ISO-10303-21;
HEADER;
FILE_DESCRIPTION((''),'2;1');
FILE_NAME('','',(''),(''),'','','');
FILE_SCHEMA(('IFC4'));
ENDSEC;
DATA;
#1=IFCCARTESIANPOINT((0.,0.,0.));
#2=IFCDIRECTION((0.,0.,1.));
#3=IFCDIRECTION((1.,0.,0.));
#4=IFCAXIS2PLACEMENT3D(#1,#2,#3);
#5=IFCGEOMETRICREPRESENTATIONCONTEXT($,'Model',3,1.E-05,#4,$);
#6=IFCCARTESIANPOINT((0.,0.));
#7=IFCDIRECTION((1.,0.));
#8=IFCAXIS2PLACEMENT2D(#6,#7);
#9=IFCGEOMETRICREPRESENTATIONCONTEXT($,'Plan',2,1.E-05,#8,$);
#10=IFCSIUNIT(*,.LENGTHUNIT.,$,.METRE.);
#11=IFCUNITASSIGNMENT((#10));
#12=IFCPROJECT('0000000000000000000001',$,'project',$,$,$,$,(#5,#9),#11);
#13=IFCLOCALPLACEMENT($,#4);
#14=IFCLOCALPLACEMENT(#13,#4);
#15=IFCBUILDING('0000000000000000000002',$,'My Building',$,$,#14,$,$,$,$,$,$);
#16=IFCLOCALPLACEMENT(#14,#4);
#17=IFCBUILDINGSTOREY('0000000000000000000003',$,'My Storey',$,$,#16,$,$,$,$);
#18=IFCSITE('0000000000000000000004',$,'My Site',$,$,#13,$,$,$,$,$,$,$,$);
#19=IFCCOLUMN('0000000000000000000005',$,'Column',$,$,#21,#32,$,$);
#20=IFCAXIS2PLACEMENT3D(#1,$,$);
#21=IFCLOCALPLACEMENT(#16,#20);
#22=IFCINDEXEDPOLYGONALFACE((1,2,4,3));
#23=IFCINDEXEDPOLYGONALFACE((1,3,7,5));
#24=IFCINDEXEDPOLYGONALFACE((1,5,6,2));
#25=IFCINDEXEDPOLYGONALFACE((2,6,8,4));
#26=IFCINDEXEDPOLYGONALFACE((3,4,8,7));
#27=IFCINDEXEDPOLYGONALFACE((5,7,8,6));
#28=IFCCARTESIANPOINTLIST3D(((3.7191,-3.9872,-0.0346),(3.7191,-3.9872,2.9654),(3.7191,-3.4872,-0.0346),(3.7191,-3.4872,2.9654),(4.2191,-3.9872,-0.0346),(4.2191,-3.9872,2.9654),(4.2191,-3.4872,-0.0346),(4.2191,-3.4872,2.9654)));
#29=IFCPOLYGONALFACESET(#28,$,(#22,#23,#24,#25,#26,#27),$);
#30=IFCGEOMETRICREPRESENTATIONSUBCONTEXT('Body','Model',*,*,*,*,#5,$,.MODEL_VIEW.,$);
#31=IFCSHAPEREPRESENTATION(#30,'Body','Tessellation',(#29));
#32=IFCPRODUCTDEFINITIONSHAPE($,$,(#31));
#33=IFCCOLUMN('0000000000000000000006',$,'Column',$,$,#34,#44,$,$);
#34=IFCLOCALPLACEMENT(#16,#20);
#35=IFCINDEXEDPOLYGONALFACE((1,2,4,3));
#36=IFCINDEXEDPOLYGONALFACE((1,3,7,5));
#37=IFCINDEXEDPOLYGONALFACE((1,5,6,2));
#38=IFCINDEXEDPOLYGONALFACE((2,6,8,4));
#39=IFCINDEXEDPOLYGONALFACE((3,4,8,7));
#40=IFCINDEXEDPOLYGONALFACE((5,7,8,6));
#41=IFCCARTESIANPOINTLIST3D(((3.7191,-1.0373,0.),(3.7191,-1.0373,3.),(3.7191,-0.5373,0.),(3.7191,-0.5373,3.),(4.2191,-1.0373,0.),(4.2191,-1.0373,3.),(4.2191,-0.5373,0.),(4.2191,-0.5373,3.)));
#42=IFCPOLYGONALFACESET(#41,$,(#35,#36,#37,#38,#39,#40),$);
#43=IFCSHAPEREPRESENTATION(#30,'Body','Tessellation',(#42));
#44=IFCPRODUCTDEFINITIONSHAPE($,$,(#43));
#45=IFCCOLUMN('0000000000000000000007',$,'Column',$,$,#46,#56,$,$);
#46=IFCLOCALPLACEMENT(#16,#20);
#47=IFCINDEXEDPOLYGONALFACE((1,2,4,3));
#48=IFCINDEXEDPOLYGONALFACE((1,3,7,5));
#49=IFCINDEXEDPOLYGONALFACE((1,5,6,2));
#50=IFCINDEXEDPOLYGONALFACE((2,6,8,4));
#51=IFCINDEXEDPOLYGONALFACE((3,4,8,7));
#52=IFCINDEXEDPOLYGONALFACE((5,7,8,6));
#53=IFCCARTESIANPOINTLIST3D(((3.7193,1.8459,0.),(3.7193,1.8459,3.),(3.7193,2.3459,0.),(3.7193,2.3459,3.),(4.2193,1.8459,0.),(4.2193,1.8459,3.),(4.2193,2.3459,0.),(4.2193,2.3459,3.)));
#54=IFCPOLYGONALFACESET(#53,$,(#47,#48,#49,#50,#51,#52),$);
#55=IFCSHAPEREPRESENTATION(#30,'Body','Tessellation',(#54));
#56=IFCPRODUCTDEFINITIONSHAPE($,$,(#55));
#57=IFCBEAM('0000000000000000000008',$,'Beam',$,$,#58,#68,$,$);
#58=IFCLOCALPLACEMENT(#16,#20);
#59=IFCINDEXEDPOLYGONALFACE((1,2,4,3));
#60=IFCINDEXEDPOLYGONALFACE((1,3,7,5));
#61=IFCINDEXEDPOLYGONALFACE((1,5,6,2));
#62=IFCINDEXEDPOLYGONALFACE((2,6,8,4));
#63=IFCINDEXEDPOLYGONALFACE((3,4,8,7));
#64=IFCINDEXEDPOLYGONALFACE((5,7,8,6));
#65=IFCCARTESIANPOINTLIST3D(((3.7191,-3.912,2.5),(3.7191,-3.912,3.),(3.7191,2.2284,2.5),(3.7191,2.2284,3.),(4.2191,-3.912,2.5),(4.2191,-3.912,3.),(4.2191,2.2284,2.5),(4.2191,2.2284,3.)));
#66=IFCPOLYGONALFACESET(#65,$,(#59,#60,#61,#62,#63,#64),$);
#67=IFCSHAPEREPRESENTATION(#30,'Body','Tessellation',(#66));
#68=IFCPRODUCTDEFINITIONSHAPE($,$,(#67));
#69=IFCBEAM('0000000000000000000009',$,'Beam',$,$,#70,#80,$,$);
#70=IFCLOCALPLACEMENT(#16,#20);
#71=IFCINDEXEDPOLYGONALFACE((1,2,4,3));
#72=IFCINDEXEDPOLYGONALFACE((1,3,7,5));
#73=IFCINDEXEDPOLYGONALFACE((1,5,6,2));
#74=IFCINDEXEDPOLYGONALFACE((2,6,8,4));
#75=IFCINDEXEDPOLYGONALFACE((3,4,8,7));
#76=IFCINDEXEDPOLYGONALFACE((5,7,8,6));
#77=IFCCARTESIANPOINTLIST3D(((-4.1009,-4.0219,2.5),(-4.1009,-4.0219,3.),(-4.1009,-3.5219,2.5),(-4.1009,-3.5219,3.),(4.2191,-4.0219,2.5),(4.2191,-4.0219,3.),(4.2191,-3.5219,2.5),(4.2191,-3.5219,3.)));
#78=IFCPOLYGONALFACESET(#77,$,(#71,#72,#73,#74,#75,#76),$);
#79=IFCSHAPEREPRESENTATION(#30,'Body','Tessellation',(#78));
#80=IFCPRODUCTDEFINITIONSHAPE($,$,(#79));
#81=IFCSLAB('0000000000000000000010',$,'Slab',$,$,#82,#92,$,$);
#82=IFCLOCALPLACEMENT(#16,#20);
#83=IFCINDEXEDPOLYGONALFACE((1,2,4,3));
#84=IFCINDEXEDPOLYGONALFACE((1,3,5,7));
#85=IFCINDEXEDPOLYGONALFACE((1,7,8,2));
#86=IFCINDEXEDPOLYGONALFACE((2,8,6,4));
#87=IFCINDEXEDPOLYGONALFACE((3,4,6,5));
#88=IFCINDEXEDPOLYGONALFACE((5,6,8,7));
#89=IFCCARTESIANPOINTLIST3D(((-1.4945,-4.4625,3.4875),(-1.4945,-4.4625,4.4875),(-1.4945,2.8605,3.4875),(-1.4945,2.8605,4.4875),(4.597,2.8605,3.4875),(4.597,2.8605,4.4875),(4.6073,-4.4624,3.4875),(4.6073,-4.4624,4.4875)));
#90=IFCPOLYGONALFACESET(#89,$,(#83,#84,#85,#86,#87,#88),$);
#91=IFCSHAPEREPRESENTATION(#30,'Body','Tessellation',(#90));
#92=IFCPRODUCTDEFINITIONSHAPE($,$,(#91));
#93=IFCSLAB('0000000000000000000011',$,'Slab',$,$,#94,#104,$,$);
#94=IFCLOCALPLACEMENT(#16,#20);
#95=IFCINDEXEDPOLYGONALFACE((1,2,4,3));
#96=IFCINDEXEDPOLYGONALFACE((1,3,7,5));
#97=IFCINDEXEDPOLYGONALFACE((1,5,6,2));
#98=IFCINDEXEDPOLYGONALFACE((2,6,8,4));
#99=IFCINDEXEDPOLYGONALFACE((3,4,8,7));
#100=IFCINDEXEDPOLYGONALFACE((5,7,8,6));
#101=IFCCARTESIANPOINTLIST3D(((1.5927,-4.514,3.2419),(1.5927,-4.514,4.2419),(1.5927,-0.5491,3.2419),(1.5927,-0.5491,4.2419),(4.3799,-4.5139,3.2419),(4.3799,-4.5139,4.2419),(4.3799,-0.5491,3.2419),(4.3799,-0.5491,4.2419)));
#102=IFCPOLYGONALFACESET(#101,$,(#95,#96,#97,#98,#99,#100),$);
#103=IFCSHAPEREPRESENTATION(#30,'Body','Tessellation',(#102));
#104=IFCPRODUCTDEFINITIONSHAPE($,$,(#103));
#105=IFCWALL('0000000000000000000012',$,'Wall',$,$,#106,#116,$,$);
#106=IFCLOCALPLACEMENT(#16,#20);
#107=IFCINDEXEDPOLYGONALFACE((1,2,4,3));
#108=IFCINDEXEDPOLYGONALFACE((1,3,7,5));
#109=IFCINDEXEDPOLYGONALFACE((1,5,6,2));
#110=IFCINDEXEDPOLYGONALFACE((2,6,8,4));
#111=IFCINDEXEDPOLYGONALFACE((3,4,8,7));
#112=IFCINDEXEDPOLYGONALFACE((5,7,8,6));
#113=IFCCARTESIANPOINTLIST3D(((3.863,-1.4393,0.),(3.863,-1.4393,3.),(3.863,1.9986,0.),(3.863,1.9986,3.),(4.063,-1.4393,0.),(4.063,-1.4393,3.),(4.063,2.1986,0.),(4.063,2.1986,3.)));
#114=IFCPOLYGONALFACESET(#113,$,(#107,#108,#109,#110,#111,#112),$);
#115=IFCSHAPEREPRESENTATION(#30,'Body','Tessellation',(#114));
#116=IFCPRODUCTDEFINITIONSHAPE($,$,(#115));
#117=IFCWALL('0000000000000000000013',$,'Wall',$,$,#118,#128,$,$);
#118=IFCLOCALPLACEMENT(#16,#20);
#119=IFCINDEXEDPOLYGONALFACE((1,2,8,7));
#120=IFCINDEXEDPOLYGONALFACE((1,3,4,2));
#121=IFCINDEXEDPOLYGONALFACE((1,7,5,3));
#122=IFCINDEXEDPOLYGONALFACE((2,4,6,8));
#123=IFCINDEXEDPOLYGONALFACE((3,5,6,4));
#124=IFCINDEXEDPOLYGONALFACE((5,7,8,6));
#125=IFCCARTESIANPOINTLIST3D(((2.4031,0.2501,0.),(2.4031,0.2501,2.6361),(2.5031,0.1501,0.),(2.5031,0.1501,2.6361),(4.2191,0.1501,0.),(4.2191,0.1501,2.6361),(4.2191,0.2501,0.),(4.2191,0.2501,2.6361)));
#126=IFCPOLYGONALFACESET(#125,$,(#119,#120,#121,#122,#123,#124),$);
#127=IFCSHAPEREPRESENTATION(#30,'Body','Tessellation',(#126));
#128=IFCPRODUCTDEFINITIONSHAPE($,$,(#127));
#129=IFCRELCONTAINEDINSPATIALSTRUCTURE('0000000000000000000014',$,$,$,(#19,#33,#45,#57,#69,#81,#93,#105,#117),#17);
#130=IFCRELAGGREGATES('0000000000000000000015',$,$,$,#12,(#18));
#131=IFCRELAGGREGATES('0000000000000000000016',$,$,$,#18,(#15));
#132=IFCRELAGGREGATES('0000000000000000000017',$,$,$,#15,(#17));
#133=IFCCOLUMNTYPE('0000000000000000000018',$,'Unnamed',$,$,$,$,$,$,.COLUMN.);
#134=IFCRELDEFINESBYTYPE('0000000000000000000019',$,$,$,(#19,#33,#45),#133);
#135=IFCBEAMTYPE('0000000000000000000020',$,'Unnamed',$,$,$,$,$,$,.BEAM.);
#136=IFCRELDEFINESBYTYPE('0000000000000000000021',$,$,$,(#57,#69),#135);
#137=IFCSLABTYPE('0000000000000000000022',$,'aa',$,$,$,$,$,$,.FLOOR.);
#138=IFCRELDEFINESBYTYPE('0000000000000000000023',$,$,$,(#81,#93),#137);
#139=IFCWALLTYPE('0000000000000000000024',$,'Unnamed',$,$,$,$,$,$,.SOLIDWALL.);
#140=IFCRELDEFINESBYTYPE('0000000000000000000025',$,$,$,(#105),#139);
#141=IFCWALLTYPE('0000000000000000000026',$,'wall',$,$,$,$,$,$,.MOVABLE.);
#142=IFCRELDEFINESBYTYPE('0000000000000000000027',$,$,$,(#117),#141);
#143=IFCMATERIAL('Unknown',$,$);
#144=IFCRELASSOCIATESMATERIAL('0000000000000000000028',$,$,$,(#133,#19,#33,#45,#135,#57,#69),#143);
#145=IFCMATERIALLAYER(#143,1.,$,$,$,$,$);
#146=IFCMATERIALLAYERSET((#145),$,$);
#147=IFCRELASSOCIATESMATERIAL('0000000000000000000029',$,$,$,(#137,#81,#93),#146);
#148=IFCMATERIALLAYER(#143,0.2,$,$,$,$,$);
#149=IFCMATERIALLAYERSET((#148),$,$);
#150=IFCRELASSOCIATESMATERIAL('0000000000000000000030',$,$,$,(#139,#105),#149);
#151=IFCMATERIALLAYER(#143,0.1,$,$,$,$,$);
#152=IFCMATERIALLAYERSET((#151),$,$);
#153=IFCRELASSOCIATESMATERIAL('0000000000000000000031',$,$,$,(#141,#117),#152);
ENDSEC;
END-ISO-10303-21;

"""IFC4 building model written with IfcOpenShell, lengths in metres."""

from ifc_helpers import new_model, si_unit, frame, origin_with_axes, origin_2d_with_axis, place, context, subcontext, project, spatial, line, indexed_curve, rectangle, outline, extrude, material, layer, layer_set, layer_usage, material_profile, profile_set, profile_usage, type_object, element, save


model = new_model("IFC4")

# Units and contexts
model_context = context("Model", 3, precision=1e-05, world=origin_with_axes())
plan_context = context("Plan", 2, precision=1e-05, world=origin_2d_with_axis())
body_context_1 = subcontext(model_context, "Body", "Model", "MODEL_VIEW")
ifc_project = project(units=[si_unit("LENGTHUNIT", "METRE")], contexts=[model_context, plan_context])

# Site, building, storey
site_placement = place(None, origin_with_axes())
site = spatial("IfcSite", under=ifc_project, at=site_placement, Name="My Site")
building_placement = place(site_placement, origin_with_axes())
building = spatial("IfcBuilding", under=site, at=building_placement, Name="My Building")
storey_placement = place(building_placement, origin_with_axes())
storey = spatial("IfcBuildingStorey", under=building, at=storey_placement, Name="My Storey")

# Columns
ifc_material = material(Name="Unknown")
ifc_material_profile_1 = material_profile(ifc_material, rectangle(XDim=0.5, YDim=0.5))
ifc_profile_set_1 = profile_set([ifc_material_profile_1])
ifc_profile_usage_1 = profile_usage(ifc_profile_set_1, cardinal=5)
column_type = type_object("IfcColumnType", Name="Unnamed", PredefinedType="COLUMN", material=ifc_profile_set_1)
column_1_placement = place(storey_placement, frame((3.9691, -3.7372, -0.0346), z_axis=(0.0, 0.0, 1.0), x_axis=(1.0, 0.0, 0.0)))
element("IfcColumn", 1, at=column_1_placement, inside=storey, type_object=column_type, material=ifc_profile_usage_1, Name="Column", context=body_context_1, shape_type="SweptSolid", body=[
    extrude(rectangle(XDim=0.5, YDim=0.5), origin_with_axes(), (0.0, 0.0, 1.0), 3.0),
])
ifc_profile_usage_2 = profile_usage(ifc_profile_set_1, cardinal=5)
column_2_placement = place(storey_placement, frame((3.9691, -0.7873, 0.0), z_axis=(0.0, 0.0, 1.0), x_axis=(1.0, 0.0, 0.0)))
element("IfcColumn", 2, at=column_2_placement, inside=storey, type_object=column_type, material=ifc_profile_usage_2, Name="Column", context=body_context_1, shape_type="SweptSolid", body=[
    extrude(rectangle(XDim=0.5, YDim=0.5), origin_with_axes(), (0.0, 0.0, 1.0), 3.0),
])
ifc_profile_usage_3 = profile_usage(ifc_profile_set_1, cardinal=5)
column_3_placement = place(storey_placement, frame((3.9693, 2.0959, 0.0), z_axis=(0.0, 0.0, 1.0), x_axis=(1.0, 0.0, 0.0)))
element("IfcColumn", 3, at=column_3_placement, inside=storey, type_object=column_type, material=ifc_profile_usage_3, Name="Column", context=body_context_1, shape_type="SweptSolid", body=[
    extrude(rectangle(XDim=0.5, YDim=0.5), origin_with_axes(), (0.0, 0.0, 1.0), 3.0),
])

# Beams
ifc_material_profile_2 = material_profile(ifc_material, rectangle(XDim=0.5, YDim=0.5))
ifc_profile_set_2 = profile_set([ifc_material_profile_2])
ifc_profile_usage_4 = profile_usage(ifc_profile_set_2, cardinal=5)
beam_type = type_object("IfcBeamType", Name="Unnamed", PredefinedType="BEAM", material=ifc_profile_set_2)
beam_1_placement = place(storey_placement, frame((3.9691, 2.2284, 2.75), z_axis=(0.0, -1.0, 0.0), x_axis=(1.0, 0.0, 0.0)))
element("IfcBeam", 4, at=beam_1_placement, inside=storey, type_object=beam_type, material=ifc_profile_usage_4, Name="Beam", context=body_context_1, shape_type="SweptSolid", body=[
    extrude(rectangle(XDim=0.5, YDim=0.5), origin_with_axes(), (0.0, 0.0, 1.0), 6.1404),
])
ifc_profile_usage_5 = profile_usage(ifc_profile_set_2, cardinal=5)
beam_2_placement = place(storey_placement, frame((4.2191, -3.7719, 2.75), z_axis=(-1.0, 0.0, 0.0), x_axis=(0.0, -1.0, 0.0)))
element("IfcBeam", 5, at=beam_2_placement, inside=storey, type_object=beam_type, material=ifc_profile_usage_5, Name="Beam", context=body_context_1, shape_type="SweptSolid", body=[
    extrude(rectangle(XDim=0.5, YDim=0.5), origin_with_axes(), (0.0, 0.0, 1.0), 8.32),
])

# Slabs
ifc_layer_1 = layer(ifc_material, 1.0)
ifc_layer_set_1 = layer_set([ifc_layer_1])
ifc_layer_usage_1 = layer_usage(ifc_layer_set_1, "AXIS3", "POSITIVE", -1.0)
slab_type = type_object("IfcSlabType", Name="aa", PredefinedType="FLOOR", material=ifc_layer_set_1)
slab_1_placement = place(storey_placement, frame((4.6073, -4.4624, 4.4875), z_axis=(0.0, 0.0, 1.0), x_axis=(1.0, 0.0, 0.0)))
element("IfcSlab", 6, at=slab_1_placement, inside=storey, type_object=slab_type, material=ifc_layer_usage_1, Name="Slab", context=body_context_1, shape_type="SweptSolid", body=[
    extrude(outline(indexed_curve([(0.0, 0.0), (-0.0102, 7.3228), (-6.1017, 7.3228), (-6.1017, -0.0001), (0.0, 0.0)])), frame((0.0, 0.0, -1.0), z_axis=(0.0, 0.0, 1.0), x_axis=(1.0, 0.0, 0.0)), (0.0, 0.0, 1.0), 1.0),
])
ifc_layer_usage_2 = layer_usage(ifc_layer_set_1, "AXIS3", "POSITIVE", -1.0)
slab_2_placement = place(storey_placement, frame((4.3799, -4.5139, 4.2419), z_axis=(0.0, 0.0, 1.0), x_axis=(1.0, 0.0, 0.0)))
element("IfcSlab", 7, at=slab_2_placement, inside=storey, type_object=slab_type, material=ifc_layer_usage_2, Name="Slab", context=body_context_1, shape_type="SweptSolid", body=[
    extrude(outline(indexed_curve([(0.0, 0.0), (0.0, 3.9648), (-2.7872, 3.9648), (-2.7872, -0.0001), (0.0, 0.0)])), frame((0.0, 0.0, -1.0), z_axis=(0.0, 0.0, 1.0), x_axis=(1.0, 0.0, 0.0)), (0.0, 0.0, 1.0), 1.0),
])

# Walls
ifc_layer_2 = layer(ifc_material, 0.2)
ifc_layer_set_2 = layer_set([ifc_layer_2])
ifc_layer_usage_3 = layer_usage(ifc_layer_set_2, "AXIS2", "POSITIVE", 0.0)
wall_type_1 = type_object("IfcWallType", Name="Unnamed", PredefinedType="SOLIDWALL", material=ifc_layer_set_2)
wall_1_placement = place(storey_placement, frame((3.863, 1.9986, 0.0), z_axis=(0.0, 0.0, 1.0), x_axis=(0.0, -1.0, 0.0)))
element("IfcWall", 8, at=wall_1_placement, inside=storey, type_object=wall_type_1, material=ifc_layer_usage_3, Name="Wall", context=body_context_1, shape_type="SweptSolid", body=[
    extrude(outline(indexed_curve([(0.0, 0.0), (-0.2, 0.2), (3.438, 0.2), (3.438, 0.0)], segments=[line(1, 2, 3, 4, 1)])), origin_with_axes(), (0.0, 0.0, 1.0), 3.0),
])
ifc_layer_3 = layer(ifc_material, 0.1)
ifc_layer_set_3 = layer_set([ifc_layer_3])
ifc_layer_usage_4 = layer_usage(ifc_layer_set_3, "AXIS2", "POSITIVE", 0.0)
wall_type_2 = type_object("IfcWallType", Name="wall", PredefinedType="MOVABLE", material=ifc_layer_set_3)
wall_2_placement = place(storey_placement, frame((4.2191, 0.2501, 0.0), z_axis=(0.0, 0.0, 1.0), x_axis=(-1.0, 0.0, 0.0)))
element("IfcWall", 9, at=wall_2_placement, inside=storey, type_object=wall_type_2, material=ifc_layer_usage_4, Name="Wall", context=body_context_1, shape_type="SweptSolid", body=[
    extrude(outline(indexed_curve([(0.0, 0.0), (0.0, 0.1), (1.716, 0.1), (1.816, 0.0)], segments=[line(1, 2, 3, 4, 1)])), origin_with_axes(), (0.0, 0.0, 1.0), 2.6361),
])

save(model, "model.ifc")
